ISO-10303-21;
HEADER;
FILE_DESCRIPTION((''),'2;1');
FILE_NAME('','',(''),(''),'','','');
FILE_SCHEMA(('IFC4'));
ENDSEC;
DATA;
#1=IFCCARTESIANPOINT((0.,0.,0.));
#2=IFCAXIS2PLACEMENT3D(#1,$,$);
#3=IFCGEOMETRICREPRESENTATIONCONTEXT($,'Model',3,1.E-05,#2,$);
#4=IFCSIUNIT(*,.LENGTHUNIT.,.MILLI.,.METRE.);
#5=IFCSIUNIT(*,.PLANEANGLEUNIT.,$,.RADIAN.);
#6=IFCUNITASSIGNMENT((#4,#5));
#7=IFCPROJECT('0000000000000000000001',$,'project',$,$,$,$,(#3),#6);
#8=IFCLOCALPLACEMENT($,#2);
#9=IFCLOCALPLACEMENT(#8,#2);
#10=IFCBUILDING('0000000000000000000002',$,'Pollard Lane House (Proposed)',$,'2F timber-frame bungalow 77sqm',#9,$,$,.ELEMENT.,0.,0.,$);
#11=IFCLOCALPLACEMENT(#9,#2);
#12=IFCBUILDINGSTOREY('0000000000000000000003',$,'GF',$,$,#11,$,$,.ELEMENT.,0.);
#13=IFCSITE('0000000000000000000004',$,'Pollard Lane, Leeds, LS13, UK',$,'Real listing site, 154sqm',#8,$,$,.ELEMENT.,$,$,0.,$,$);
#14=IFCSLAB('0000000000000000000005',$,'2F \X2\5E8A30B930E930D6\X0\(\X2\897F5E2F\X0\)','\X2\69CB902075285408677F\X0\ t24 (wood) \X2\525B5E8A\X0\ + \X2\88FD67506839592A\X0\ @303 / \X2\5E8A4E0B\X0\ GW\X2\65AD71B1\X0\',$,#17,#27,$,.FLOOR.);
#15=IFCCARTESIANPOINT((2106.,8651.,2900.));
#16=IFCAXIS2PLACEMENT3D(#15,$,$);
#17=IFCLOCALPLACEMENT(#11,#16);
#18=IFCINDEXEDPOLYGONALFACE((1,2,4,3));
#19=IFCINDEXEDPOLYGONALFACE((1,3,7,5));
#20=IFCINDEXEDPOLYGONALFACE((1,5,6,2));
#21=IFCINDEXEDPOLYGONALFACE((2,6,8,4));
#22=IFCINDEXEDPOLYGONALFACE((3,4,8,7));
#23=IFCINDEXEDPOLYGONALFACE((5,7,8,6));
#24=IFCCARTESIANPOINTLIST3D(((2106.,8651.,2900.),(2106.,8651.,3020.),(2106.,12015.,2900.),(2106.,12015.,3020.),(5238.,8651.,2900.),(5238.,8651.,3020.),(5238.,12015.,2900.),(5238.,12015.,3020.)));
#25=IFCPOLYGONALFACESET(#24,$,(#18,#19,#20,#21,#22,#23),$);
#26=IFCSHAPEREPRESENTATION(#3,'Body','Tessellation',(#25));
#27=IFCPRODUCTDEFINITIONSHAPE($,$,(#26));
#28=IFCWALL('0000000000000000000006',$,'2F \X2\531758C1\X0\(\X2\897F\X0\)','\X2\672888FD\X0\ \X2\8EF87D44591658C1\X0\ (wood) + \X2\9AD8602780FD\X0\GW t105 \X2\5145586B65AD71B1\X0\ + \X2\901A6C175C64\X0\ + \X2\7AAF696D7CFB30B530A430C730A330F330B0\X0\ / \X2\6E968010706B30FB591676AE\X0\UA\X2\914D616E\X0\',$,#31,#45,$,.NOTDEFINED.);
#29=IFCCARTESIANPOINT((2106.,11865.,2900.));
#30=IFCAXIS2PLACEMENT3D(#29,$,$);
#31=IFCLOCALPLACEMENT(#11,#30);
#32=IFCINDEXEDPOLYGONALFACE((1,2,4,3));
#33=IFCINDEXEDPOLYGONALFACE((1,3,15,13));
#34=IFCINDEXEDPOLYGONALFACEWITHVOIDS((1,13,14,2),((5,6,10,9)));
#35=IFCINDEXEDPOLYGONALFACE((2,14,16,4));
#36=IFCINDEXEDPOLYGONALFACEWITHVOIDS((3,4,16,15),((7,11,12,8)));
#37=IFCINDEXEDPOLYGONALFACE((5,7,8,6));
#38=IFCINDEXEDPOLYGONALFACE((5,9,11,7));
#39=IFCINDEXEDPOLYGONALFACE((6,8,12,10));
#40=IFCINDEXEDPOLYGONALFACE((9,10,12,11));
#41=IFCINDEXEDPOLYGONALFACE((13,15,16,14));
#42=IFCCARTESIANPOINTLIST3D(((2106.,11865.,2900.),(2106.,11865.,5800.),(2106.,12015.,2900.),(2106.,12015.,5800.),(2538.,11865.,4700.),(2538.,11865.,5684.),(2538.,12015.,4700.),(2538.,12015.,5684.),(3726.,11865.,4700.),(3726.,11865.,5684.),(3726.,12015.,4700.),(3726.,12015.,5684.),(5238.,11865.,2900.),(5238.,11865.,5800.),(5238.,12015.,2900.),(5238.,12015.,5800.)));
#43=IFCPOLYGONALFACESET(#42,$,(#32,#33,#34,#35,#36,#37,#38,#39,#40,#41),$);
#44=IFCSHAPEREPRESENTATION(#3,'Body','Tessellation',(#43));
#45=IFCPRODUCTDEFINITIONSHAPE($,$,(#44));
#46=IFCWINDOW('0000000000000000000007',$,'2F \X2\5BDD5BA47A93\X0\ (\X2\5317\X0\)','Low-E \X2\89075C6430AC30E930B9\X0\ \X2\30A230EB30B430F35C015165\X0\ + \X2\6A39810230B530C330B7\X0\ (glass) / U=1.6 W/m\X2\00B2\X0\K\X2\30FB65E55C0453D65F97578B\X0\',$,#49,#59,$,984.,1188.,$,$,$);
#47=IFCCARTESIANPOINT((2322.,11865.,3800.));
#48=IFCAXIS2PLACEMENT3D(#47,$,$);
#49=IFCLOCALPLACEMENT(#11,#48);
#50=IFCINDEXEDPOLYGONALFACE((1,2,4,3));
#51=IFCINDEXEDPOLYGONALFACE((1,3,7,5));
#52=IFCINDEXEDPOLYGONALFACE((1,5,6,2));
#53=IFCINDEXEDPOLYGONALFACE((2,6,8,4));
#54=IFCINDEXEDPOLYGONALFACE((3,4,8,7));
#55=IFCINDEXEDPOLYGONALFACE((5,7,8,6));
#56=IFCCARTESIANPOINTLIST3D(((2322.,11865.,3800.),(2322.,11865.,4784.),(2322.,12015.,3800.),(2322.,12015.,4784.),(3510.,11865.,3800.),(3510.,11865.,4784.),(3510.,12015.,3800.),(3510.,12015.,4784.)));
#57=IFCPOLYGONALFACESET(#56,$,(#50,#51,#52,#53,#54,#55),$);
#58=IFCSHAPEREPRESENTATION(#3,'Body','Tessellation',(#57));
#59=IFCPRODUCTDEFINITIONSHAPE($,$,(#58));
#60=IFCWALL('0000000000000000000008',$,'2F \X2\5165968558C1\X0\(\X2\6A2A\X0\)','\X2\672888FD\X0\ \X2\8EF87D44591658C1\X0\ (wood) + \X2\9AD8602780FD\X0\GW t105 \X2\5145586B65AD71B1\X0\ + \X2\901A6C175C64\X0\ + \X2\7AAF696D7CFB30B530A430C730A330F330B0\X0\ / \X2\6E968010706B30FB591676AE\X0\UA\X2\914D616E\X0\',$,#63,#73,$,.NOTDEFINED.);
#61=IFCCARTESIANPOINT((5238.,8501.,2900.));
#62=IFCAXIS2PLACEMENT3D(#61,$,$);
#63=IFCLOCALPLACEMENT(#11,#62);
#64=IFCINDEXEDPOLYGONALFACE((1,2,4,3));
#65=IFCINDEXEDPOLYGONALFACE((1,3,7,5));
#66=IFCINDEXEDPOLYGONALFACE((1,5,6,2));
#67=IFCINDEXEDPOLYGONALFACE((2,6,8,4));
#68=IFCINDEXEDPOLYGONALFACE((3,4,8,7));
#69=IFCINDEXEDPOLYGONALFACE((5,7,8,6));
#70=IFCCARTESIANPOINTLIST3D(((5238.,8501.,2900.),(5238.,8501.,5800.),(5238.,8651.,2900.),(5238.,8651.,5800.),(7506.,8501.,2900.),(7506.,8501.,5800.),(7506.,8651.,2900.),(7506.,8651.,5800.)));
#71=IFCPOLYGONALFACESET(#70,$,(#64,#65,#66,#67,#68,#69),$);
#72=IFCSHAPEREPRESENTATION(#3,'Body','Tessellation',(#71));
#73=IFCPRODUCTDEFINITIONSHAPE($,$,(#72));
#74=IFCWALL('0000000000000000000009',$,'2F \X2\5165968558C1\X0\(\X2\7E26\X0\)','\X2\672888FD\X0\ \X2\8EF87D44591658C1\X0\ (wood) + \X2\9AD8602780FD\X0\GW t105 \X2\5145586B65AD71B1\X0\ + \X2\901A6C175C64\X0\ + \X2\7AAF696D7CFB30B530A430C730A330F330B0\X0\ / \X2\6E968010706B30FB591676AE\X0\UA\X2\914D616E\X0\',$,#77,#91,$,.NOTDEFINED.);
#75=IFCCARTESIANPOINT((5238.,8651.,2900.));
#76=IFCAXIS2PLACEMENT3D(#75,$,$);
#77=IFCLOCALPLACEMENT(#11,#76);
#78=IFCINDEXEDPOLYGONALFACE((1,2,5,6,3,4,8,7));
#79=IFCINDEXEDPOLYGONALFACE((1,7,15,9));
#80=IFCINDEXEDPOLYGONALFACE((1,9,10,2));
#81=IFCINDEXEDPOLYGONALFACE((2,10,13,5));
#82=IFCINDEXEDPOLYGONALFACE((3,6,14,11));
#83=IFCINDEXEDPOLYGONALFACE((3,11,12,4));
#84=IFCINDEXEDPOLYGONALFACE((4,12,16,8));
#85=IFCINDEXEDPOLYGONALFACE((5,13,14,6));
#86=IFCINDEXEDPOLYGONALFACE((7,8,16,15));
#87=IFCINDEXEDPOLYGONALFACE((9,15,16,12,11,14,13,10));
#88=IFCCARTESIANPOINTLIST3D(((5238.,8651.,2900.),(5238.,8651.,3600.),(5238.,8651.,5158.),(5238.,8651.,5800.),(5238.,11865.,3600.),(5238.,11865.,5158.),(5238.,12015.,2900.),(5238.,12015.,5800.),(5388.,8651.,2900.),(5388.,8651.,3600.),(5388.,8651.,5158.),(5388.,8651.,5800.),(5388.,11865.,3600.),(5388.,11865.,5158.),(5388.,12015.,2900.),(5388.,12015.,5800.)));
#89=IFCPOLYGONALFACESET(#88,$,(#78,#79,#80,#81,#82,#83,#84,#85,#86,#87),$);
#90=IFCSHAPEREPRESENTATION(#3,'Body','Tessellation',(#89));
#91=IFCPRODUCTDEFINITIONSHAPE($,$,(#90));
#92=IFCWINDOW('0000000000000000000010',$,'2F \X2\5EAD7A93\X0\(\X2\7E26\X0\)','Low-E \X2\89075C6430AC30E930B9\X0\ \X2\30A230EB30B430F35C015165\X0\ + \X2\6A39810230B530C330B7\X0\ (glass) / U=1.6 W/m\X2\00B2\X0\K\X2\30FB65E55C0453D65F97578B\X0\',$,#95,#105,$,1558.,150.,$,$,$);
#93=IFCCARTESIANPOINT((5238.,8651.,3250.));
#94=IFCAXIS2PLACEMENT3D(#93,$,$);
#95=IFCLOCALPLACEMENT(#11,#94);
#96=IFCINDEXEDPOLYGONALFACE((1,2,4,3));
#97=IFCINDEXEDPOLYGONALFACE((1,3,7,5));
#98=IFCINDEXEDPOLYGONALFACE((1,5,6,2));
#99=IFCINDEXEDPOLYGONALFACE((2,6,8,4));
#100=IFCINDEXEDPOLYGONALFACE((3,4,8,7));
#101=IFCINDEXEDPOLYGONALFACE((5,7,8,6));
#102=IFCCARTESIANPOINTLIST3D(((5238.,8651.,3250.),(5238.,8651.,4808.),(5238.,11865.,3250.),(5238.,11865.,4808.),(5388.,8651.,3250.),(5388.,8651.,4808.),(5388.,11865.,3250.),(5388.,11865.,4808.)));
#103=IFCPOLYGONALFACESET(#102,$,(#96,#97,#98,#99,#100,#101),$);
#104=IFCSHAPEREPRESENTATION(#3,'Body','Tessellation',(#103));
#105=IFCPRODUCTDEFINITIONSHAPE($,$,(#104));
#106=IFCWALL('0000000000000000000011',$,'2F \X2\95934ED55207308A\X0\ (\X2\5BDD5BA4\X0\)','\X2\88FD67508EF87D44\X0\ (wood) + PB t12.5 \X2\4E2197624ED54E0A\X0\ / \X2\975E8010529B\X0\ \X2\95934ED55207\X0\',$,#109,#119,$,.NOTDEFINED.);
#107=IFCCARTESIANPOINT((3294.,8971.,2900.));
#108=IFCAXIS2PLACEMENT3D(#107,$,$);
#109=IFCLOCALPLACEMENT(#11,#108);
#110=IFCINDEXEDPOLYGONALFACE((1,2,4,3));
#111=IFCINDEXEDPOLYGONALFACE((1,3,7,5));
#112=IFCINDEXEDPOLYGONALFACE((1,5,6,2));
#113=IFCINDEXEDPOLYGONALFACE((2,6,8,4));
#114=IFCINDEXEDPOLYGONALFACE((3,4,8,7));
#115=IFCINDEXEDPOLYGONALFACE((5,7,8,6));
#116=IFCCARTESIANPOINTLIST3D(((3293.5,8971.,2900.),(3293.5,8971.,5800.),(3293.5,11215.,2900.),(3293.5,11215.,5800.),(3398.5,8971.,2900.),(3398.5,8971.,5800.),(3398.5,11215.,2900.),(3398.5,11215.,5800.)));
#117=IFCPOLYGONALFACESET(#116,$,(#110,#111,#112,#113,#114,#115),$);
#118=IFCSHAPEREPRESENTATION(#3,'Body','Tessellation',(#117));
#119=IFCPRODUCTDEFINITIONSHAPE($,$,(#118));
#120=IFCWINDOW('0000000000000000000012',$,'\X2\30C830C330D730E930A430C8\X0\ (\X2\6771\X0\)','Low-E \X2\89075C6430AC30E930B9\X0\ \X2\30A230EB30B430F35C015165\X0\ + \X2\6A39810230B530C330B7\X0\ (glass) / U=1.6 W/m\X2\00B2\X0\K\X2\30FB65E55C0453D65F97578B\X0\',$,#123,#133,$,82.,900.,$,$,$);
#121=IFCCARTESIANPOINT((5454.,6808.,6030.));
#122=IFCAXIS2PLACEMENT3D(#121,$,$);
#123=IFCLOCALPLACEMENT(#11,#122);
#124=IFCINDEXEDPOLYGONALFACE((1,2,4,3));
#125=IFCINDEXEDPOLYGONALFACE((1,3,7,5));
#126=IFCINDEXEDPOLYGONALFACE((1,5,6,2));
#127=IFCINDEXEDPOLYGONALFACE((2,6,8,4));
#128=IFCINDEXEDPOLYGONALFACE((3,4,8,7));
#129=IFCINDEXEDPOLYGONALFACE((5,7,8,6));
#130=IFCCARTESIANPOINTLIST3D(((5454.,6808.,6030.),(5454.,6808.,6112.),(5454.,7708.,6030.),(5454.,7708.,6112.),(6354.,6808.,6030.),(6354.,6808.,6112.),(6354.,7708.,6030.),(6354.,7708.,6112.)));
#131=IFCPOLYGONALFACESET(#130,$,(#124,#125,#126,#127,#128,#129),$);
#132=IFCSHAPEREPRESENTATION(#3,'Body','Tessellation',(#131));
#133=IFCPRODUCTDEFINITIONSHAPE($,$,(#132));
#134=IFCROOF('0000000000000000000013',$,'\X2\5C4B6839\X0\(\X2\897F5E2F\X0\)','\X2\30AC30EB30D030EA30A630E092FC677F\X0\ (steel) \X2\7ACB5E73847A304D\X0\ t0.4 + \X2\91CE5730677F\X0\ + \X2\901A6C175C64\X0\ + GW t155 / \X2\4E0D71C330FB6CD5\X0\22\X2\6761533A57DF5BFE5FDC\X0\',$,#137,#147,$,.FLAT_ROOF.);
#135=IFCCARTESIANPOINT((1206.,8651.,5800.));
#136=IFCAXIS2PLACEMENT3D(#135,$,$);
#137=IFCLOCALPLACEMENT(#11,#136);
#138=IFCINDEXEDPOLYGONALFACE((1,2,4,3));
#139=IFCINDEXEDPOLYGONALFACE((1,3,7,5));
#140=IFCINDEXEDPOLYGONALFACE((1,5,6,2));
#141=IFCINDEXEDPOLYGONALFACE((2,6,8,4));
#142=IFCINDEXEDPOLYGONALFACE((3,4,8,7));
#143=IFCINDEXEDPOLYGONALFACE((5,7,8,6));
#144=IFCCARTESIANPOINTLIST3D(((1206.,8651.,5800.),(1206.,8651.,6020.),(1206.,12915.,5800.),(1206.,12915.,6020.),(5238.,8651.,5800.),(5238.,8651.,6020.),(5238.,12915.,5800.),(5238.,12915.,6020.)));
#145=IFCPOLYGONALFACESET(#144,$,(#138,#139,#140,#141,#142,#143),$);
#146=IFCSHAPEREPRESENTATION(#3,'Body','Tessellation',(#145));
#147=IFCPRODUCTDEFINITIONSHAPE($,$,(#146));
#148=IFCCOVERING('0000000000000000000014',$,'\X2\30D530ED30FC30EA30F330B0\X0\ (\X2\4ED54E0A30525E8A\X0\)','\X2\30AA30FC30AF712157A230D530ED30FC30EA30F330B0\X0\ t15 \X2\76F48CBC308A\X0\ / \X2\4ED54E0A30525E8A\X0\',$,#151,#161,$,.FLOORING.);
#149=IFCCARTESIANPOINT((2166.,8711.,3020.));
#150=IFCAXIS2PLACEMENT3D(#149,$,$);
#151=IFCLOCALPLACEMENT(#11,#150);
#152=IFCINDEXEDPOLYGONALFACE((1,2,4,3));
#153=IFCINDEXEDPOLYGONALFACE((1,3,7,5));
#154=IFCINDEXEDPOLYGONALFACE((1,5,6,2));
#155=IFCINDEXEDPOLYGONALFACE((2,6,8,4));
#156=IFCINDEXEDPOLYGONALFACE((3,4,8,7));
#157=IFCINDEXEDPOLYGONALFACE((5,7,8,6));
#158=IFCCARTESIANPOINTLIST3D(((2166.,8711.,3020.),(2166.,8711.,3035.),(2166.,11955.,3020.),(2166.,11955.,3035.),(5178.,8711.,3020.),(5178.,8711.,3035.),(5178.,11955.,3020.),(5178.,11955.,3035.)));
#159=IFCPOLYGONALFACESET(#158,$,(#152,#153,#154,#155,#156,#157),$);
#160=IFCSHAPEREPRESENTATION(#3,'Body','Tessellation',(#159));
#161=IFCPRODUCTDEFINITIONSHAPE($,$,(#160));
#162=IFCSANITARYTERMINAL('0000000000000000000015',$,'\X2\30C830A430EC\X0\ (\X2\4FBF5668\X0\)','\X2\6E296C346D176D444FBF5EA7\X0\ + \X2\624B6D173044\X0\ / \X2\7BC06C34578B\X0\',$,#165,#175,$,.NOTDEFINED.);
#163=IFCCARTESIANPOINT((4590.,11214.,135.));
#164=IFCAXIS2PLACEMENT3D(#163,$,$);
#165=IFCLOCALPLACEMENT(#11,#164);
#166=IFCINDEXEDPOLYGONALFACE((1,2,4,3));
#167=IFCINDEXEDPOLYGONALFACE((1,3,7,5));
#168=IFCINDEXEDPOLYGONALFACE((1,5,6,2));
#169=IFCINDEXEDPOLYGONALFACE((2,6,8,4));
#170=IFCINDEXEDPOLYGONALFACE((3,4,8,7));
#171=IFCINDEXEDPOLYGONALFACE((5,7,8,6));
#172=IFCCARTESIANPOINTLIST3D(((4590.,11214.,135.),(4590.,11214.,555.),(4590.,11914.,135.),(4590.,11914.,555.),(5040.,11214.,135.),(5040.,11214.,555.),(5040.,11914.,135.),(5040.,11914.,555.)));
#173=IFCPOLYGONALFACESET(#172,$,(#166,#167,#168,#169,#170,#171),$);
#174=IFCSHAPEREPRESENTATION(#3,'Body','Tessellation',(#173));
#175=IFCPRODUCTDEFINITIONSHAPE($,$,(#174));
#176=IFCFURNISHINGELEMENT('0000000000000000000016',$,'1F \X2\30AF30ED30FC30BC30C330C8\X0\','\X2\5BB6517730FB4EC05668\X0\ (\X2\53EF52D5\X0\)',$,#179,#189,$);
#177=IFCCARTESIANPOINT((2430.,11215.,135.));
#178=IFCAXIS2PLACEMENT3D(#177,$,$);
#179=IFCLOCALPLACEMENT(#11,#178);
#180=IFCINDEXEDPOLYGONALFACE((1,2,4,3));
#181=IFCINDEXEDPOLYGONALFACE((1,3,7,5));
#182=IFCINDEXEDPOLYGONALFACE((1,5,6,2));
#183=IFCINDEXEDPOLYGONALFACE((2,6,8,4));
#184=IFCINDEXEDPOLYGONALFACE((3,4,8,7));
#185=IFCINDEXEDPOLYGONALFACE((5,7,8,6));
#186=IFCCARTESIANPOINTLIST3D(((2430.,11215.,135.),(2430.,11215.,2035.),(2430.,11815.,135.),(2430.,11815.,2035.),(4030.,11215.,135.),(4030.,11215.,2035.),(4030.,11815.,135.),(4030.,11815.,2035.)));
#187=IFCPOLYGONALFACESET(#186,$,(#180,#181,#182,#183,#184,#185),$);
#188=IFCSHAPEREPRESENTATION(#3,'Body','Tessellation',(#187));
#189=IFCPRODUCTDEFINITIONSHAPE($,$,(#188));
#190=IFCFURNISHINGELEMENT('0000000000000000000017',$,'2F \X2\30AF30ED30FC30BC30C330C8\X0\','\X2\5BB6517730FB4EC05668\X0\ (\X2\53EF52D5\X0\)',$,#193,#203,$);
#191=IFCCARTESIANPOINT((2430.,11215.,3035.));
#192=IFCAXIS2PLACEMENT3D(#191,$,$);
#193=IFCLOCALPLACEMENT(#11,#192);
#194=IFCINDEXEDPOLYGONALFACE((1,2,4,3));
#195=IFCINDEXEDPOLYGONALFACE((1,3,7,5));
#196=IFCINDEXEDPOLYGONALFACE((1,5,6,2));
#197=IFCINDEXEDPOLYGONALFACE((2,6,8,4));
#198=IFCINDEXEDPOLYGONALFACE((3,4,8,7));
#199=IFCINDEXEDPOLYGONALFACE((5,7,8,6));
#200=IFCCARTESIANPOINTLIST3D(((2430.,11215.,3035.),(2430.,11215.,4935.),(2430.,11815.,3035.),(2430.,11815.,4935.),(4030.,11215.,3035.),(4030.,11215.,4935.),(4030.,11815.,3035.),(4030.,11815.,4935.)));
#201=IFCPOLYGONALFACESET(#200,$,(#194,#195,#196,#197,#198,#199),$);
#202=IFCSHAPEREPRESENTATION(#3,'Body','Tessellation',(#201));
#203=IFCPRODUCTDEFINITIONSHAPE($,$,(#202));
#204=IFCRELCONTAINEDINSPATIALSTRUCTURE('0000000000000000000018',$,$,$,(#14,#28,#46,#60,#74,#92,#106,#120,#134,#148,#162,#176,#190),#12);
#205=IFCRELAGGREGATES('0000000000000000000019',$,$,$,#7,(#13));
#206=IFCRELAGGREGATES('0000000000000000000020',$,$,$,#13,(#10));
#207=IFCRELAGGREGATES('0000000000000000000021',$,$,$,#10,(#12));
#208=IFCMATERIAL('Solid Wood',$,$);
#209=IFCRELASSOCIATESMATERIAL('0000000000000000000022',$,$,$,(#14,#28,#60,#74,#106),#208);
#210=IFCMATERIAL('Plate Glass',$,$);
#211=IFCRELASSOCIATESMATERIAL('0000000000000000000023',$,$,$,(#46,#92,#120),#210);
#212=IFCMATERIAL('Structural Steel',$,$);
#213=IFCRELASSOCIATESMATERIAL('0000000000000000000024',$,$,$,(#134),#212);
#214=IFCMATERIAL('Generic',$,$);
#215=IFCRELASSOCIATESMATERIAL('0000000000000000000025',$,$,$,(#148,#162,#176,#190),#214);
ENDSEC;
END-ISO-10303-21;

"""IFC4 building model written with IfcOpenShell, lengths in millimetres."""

from ifc_helpers import new_model, si_unit, frame, frame_2d, origin, place, context, project, spatial, rectangle, extrude, material, element, fill, save


model = new_model("IFC4")

# Units and contexts
model_context = context("Model", 3, precision=1e-05, world=origin())
ifc_project = project(units=[si_unit("LENGTHUNIT", "METRE", prefix="MILLI"), si_unit("PLANEANGLEUNIT", "RADIAN")], contexts=[model_context])

# Site, building, storey
site_placement = place(None, origin())
site = spatial("IfcSite", under=ifc_project, at=site_placement, Name="Pollard Lane, Leeds, LS13, UK", ObjectType="Real listing site, 154sqm", CompositionType="ELEMENT", RefElevation=0.0)
building_placement = place(site_placement, origin())
building = spatial("IfcBuilding", under=site, at=building_placement, Name="Pollard Lane House (Proposed)", ObjectType="2F timber-frame bungalow 77sqm", CompositionType="ELEMENT", ElevationOfRefHeight=0.0, ElevationOfTerrain=0.0)
storey_placement = place(building_placement, origin())
storey = spatial("IfcBuildingStorey", under=building, at=storey_placement, Name="GF", CompositionType="ELEMENT", Elevation=0.0)

# Slab
ifc_material_1 = material(Name="Solid Wood")
slab_placement = place(storey_placement, frame((2106.0, 8651.0, 2900.0)))
element("IfcSlab", 1, at=slab_placement, inside=storey, material=ifc_material_1, Name="2F 床スラブ(西帯)", Description="構造用合板 t24 (wood) 剛床 + 製材根太 @303 / 床下 GW断熱", PredefinedType="FLOOR", context=model_context, shape_type="SweptSolid", body=[
    extrude(rectangle(XDim=3132.0, YDim=3364.0, at=frame_2d((1566.0, 1682.0))), frame((2106.0, 8651.0, 2900.0)), (0.0, 0.0, 1.0), 120.0),
])

# Wall, opening, window
wall_1_placement = place(storey_placement, frame((2106.0, 11865.0, 2900.0)))
wall_1 = element("IfcWall", 2, at=wall_1_placement, inside=storey, material=ifc_material_1, Name="2F 北壁(西)", Description="木製 軸組外壁 (wood) + 高性能GW t105 充填断熱 + 通気層 + 窯業系サイディング / 準耐火・外皮UA配慮", PredefinedType="NOTDEFINED", context=model_context, shape_type="SweptSolid", body=[
    extrude(rectangle(XDim=3132.0, YDim=150.0, at=frame_2d((1566.0, 75.0))), frame((2106.0, 11865.0, 2900.0)), (0.0, 0.0, 1.0), 2900.0),
])
opening_1_placement = place(storey_placement, frame((2322.0, 11865.0, 3800.0)))
opening_1 = element("IfcOpeningElement", 3, at=opening_1_placement, cuts=wall_1, PredefinedType="NOTDEFINED", context=model_context, shape_type="SweptSolid", body=[
    extrude(rectangle(XDim=1188.0, YDim=150.0, at=frame_2d((594.0, 75.0))), frame((2322.0, 11865.0, 3800.0)), (0.0, 0.0, 1.0), 984.0),
])
ifc_material_2 = material(Name="Plate Glass")
window_1_placement = place(storey_placement, frame((2322.0, 11865.0, 3800.0)))
window_1 = element("IfcWindow", 4, at=window_1_placement, inside=storey, material=ifc_material_2, Name="2F 寝室窓 (北)", Description="Low-E 複層ガラス アルゴン封入 + 樹脂サッシ (glass) / U=1.6 W/m²K・日射取得型", OverallHeight=984.0, OverallWidth=1188.0, context=model_context, shape_type="SweptSolid", body=[
    extrude(rectangle(XDim=1188.0, YDim=150.0, at=frame_2d((594.0, 75.0))), frame((2322.0, 11865.0, 3800.0)), (0.0, 0.0, 1.0), 984.0),
])
fill(opening_1, window_1)

# Wall
wall_2_placement = place(storey_placement, frame((5238.0, 8501.0, 2900.0)))
element("IfcWall", 5, at=wall_2_placement, inside=storey, material=ifc_material_1, Name="2F 入隅壁(横)", Description="木製 軸組外壁 (wood) + 高性能GW t105 充填断熱 + 通気層 + 窯業系サイディング / 準耐火・外皮UA配慮", PredefinedType="NOTDEFINED", context=model_context, shape_type="SweptSolid", body=[
    extrude(rectangle(XDim=2268.0, YDim=150.0, at=frame_2d((1134.0, 75.0))), frame((5238.0, 8501.0, 2900.0)), (0.0, 0.0, 1.0), 2900.0),
])

# Wall, opening, window
wall_3_placement = place(storey_placement, frame((5238.0, 8651.0, 2900.0)))
wall_3 = element("IfcWall", 6, at=wall_3_placement, inside=storey, material=ifc_material_1, Name="2F 入隅壁(縦)", Description="木製 軸組外壁 (wood) + 高性能GW t105 充填断熱 + 通気層 + 窯業系サイディング / 準耐火・外皮UA配慮", PredefinedType="NOTDEFINED", context=model_context, shape_type="SweptSolid", body=[
    extrude(rectangle(XDim=150.0, YDim=3364.0, at=frame_2d((75.0, 1682.0))), frame((5238.0, 8651.0, 2900.0)), (0.0, 0.0, 1.0), 2900.0),
])
opening_2_placement = place(storey_placement, frame((5238.0, 8651.0, 3250.0)))
opening_2 = element("IfcOpeningElement", 7, at=opening_2_placement, cuts=wall_3, PredefinedType="NOTDEFINED", context=model_context, shape_type="SweptSolid", body=[
    extrude(rectangle(XDim=150.0, YDim=3214.0, at=frame_2d((75.0, 1607.0))), frame((5238.0, 8651.0, 3250.0)), (0.0, 0.0, 1.0), 1558.0),
])
window_2_placement = place(storey_placement, frame((5238.0, 8651.0, 3250.0)))
window_2 = element("IfcWindow", 8, at=window_2_placement, inside=storey, material=ifc_material_2, Name="2F 庭窓(縦)", Description="Low-E 複層ガラス アルゴン封入 + 樹脂サッシ (glass) / U=1.6 W/m²K・日射取得型", OverallHeight=1558.0, OverallWidth=150.0, context=model_context, shape_type="SweptSolid", body=[
    extrude(rectangle(XDim=150.0, YDim=3214.0, at=frame_2d((75.0, 1607.0))), frame((5238.0, 8651.0, 3250.0)), (0.0, 0.0, 1.0), 1558.0),
])
fill(opening_2, window_2)

# Wall
wall_4_placement = place(storey_placement, frame((3294.0, 8971.0, 2900.0)))
element("IfcWall", 9, at=wall_4_placement, inside=storey, material=ifc_material_1, Name="2F 間仕切り (寝室)", Description="製材軸組 (wood) + PB t12.5 両面仕上 / 非耐力 間仕切", PredefinedType="NOTDEFINED", context=model_context, shape_type="SweptSolid", body=[
    extrude(rectangle(XDim=105.0, YDim=2244.0, at=frame_2d((52.0, 1122.0))), frame((3294.0, 8971.0, 2900.0)), (0.0, 0.0, 1.0), 2900.0),
])

# Window
window_3_placement = place(storey_placement, frame((5454.0, 6808.0, 6030.0)))
element("IfcWindow", 10, at=window_3_placement, inside=storey, material=ifc_material_2, Name="トップライト (東)", Description="Low-E 複層ガラス アルゴン封入 + 樹脂サッシ (glass) / U=1.6 W/m²K・日射取得型", OverallHeight=82.0, OverallWidth=900.0, context=model_context, shape_type="SweptSolid", body=[
    extrude(rectangle(XDim=900.0, YDim=900.0, at=frame_2d((450.0, 450.0))), frame((5454.0, 6808.0, 6030.0)), (0.0, 0.0, 1.0), 82.0),
])

# Roof
ifc_material_3 = material(Name="Structural Steel")
for number, where, name in (
    (11, (1206.0, 8651.0, 5800.0), "屋根(西帯)"),
):
    element("IfcRoof", number, at=place(storey_placement, frame(where)), inside=storey, material=ifc_material_3, Name=name, Description="ガルバリウム鋼板 (steel) 立平葺き t0.4 + 野地板 + 通気層 + GW t155 / 不燃・法22条区域対応", PredefinedType="FLAT_ROOF", context=model_context, shape_type="SweptSolid", body=[
        extrude(rectangle(XDim=4032.0, YDim=4264.0, at=frame_2d((2016.0, 2132.0))), frame((1206.0, 8651.0, 5800.0)), (0.0, 0.0, 1.0), 220.0),
    ])

# Covering
ifc_material_4 = material(Name="Generic")
covering_placement = place(storey_placement, frame((2166.0, 8711.0, 3020.0)))
element("IfcCovering", 12, at=covering_placement, inside=storey, material=ifc_material_4, Name="フローリング (仕上げ床)", Description="オーク無垢フローリング t15 直貼り / 仕上げ床", PredefinedType="FLOORING", context=model_context, shape_type="SweptSolid", body=[
    extrude(rectangle(XDim=3012.0, YDim=3244.0, at=frame_2d((1506.0, 1622.0))), frame((2166.0, 8711.0, 3020.0)), (0.0, 0.0, 1.0), 15.0),
])

# Sanitary terminal
sanitary_terminal_placement = place(storey_placement, frame((4590.0, 11214.0, 135.0)))
element("IfcSanitaryTerminal", 13, at=sanitary_terminal_placement, inside=storey, material=ifc_material_4, Name="トイレ (便器)", Description="温水洗浄便座 + 手洗い / 節水型", PredefinedType="NOTDEFINED", context=model_context, shape_type="SweptSolid", body=[
    extrude(rectangle(XDim=450.0, YDim=700.0, at=frame_2d((225.0, 350.0))), frame((4590.0, 11214.0, 135.0)), (0.0, 0.0, 1.0), 420.0),
])

# Furnishing elements
furnishing_1_placement = place(storey_placement, frame((2430.0, 11215.0, 135.0)))
element("IfcFurnishingElement", 14, at=furnishing_1_placement, inside=storey, material=ifc_material_4, Name="1F クローゼット", Description="家具・什器 (可動)", context=model_context, shape_type="SweptSolid", body=[
    extrude(rectangle(XDim=1600.0, YDim=600.0, at=frame_2d((800.0, 300.0))), frame((2430.0, 11215.0, 135.0)), (0.0, 0.0, 1.0), 1900.0),
])
furnishing_2_placement = place(storey_placement, frame((2430.0, 11215.0, 3035.0)))
element("IfcFurnishingElement", 15, at=furnishing_2_placement, inside=storey, material=ifc_material_4, Name="2F クローゼット", Description="家具・什器 (可動)", context=model_context, shape_type="SweptSolid", body=[
    extrude(rectangle(XDim=1600.0, YDim=600.0, at=frame_2d((800.0, 300.0))), frame((2430.0, 11215.0, 3035.0)), (0.0, 0.0, 1.0), 1900.0),
])

save(model, "model.ifc")
